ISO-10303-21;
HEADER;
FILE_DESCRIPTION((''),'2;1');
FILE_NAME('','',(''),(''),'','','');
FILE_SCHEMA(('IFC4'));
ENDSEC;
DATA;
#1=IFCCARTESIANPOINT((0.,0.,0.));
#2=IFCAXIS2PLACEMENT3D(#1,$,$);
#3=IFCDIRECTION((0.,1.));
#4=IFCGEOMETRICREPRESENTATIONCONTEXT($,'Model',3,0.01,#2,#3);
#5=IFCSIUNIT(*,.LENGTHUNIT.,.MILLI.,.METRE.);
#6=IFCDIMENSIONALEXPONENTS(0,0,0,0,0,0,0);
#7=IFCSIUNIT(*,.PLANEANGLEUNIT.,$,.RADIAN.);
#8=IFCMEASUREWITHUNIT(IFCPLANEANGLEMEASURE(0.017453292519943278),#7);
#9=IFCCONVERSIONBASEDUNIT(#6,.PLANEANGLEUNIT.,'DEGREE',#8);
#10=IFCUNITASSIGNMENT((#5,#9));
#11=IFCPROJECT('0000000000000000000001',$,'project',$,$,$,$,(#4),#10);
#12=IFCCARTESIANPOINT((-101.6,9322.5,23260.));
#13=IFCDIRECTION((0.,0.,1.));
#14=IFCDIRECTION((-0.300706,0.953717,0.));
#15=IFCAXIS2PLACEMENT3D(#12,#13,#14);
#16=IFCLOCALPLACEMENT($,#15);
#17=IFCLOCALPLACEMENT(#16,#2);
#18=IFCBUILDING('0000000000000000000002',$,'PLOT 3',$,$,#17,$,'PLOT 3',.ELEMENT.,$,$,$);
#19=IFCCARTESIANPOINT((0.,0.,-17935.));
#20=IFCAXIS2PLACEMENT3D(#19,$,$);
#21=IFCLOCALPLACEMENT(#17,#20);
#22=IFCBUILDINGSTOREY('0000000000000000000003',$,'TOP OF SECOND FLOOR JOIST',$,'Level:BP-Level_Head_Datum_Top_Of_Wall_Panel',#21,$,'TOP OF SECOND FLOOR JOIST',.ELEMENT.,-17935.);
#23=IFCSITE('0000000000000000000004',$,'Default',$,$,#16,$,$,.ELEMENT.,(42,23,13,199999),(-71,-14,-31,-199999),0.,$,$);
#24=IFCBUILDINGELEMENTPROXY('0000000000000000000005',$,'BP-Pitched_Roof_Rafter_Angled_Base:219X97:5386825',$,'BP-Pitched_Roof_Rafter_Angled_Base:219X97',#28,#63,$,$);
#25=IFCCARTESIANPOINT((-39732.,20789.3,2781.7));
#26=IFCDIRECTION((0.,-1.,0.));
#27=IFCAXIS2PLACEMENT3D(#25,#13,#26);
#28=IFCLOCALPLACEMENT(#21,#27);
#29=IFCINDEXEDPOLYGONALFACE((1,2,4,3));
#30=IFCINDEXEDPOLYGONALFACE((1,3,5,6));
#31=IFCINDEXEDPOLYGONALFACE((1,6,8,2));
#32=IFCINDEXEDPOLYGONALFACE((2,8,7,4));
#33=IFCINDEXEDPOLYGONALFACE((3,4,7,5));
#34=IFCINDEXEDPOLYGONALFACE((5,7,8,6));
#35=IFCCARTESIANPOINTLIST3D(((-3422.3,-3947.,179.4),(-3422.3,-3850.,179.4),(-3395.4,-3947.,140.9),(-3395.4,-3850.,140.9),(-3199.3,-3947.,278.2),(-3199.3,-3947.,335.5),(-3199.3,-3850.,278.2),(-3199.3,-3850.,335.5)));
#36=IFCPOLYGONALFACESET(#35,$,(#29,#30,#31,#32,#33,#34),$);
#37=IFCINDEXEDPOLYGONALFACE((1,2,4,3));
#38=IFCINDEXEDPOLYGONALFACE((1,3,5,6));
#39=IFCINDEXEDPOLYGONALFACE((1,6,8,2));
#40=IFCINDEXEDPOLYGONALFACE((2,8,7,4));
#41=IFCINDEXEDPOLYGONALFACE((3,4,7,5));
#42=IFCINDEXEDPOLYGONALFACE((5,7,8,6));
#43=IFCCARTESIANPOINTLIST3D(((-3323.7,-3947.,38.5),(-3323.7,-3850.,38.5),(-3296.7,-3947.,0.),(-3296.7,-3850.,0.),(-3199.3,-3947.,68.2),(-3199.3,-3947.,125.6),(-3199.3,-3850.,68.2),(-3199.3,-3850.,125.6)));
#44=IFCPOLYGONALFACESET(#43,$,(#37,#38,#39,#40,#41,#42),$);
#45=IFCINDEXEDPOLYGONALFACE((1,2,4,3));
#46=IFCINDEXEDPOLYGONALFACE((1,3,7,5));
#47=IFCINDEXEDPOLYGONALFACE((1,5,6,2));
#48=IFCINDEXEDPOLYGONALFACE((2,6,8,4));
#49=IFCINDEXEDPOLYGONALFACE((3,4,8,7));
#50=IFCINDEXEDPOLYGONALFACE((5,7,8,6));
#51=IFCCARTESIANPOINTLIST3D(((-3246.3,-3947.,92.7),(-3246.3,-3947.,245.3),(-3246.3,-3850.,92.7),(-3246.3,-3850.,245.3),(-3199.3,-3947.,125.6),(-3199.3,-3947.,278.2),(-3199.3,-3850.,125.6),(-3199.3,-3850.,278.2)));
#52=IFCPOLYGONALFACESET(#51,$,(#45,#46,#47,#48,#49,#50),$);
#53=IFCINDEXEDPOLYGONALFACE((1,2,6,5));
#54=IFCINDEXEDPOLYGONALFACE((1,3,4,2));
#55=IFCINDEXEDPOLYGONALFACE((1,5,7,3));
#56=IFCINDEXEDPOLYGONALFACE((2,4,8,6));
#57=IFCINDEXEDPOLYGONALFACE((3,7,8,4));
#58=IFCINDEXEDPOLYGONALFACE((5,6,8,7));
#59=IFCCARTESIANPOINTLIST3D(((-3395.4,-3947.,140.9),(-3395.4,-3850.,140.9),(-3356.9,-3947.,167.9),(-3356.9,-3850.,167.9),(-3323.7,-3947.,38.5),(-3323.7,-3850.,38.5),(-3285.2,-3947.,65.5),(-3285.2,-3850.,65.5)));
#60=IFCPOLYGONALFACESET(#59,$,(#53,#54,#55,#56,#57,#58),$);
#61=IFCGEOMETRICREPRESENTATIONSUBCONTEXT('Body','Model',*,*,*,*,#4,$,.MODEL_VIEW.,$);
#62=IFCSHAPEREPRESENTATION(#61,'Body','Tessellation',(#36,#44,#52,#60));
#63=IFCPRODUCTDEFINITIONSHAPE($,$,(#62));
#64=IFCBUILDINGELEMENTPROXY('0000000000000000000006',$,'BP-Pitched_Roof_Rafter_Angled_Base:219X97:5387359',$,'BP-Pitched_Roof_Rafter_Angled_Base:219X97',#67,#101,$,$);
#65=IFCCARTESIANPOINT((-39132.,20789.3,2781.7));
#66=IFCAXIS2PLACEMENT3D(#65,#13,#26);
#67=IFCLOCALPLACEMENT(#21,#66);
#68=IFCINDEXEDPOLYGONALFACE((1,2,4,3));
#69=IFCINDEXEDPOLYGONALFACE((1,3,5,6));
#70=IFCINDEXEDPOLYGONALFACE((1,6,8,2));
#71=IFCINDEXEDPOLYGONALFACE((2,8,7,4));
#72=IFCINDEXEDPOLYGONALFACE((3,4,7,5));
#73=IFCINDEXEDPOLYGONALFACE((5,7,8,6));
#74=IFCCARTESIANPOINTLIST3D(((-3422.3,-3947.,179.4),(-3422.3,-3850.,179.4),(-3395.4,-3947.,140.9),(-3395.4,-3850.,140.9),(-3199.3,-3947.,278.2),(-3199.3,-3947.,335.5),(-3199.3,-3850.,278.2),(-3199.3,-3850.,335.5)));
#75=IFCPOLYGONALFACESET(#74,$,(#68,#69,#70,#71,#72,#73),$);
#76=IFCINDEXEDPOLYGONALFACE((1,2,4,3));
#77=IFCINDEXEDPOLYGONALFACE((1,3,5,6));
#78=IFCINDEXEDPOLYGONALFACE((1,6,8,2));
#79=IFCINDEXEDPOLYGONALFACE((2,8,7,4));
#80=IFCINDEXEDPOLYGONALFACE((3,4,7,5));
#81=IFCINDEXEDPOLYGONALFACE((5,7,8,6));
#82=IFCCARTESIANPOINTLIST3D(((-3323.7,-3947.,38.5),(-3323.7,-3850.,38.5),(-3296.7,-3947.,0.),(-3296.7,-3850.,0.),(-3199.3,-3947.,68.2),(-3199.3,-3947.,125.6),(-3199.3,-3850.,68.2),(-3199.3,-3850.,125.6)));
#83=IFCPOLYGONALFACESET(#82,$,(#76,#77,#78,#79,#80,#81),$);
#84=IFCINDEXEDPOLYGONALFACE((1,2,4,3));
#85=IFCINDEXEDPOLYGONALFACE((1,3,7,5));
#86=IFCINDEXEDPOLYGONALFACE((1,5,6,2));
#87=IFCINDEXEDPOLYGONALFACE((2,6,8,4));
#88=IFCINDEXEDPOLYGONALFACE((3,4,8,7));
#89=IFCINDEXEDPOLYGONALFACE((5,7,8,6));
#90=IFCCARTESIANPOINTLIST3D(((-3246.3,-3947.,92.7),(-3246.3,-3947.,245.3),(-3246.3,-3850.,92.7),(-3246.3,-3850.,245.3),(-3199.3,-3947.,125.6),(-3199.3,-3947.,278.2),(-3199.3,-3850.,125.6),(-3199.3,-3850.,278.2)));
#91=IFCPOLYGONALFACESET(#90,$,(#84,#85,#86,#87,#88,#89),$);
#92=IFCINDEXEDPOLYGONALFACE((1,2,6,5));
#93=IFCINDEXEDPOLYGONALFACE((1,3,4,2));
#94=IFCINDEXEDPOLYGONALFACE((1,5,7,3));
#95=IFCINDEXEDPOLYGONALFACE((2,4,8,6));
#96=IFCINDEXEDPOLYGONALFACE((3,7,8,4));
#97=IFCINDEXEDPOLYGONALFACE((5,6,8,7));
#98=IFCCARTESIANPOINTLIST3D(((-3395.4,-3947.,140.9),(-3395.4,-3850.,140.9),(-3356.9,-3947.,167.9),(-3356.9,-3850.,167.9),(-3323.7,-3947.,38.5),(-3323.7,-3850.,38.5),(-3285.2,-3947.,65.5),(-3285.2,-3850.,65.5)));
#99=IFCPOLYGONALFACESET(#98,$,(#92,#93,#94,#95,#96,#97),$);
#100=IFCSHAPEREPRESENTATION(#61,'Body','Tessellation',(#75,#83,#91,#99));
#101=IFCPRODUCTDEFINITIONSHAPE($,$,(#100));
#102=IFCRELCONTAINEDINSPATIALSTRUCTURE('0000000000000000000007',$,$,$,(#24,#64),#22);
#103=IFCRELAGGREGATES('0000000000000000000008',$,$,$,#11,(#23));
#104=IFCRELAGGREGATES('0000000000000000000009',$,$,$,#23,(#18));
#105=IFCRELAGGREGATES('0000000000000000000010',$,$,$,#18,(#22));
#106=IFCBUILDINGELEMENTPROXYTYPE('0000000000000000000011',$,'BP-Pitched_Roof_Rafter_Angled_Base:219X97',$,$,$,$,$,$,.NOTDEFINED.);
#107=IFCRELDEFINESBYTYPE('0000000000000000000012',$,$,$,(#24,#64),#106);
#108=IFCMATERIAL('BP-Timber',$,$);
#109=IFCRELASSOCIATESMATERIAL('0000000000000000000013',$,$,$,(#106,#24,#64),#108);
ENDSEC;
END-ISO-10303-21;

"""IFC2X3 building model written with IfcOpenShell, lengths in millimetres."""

from ifc_helpers import new_model, entity, si_unit, converted_unit, direction, frame, frame_2d, origin, place, context, subcontext, project, spatial, polyline, rectangle, outline, extrude, source, transform, mapped, material, type_object, type_shapes, element, save


model = new_model("IFC2X3")

# Units and contexts
model_context = context("Model", 3, precision=0.01, world=origin(), true_north=direction((0.0, 1.0)))
body_context = subcontext(model_context, "Body", "Model", "MODEL_VIEW")
ifc_project = project(units=[si_unit("LENGTHUNIT", "METRE", prefix="MILLI"), converted_unit("PLANEANGLEUNIT", "DEGREE", entity("IfcPlaneAngleMeasure", 0.017453292519943278), si_unit("PLANEANGLEUNIT", "RADIAN"), dimensions=[0, 0, 0, 0, 0, 0, 0])], contexts=[model_context])

# Site, building, storey
site_placement = place(None, frame((-101.6, 9322.5, 23260.0), z_axis=(0.0, 0.0, 1.0), x_axis=(-0.300706, 0.953717, 0.0)))
site = spatial("IfcSite", under=ifc_project, at=site_placement, Name="Default", CompositionType="ELEMENT", RefLatitude=(42, 23, 13, 199999), RefLongitude=(-71, -14, -31, -199999), RefElevation=0.0)
building_placement = place(site_placement, origin())
building = spatial("IfcBuilding", under=site, at=building_placement, Name="PLOT 3", LongName="PLOT 3", CompositionType="ELEMENT")
storey_placement = place(building_placement, frame((0.0, 0.0, -17935.0)))
storey = spatial("IfcBuildingStorey", under=building, at=storey_placement, Name="TOP OF SECOND FLOOR JOIST", ObjectType="Level:BP-Level_Head_Datum_Top_Of_Wall_Panel", LongName="TOP OF SECOND FLOOR JOIST", CompositionType="ELEMENT", Elevation=-17935.0)

# Building element proxies
ifc_material_1 = material(Name="BP-Timber")
building_element_proxy_type_1 = type_object("IfcBuildingElementProxyType", Name="BP-Pitched_Roof_Rafter_Angled_Base:219X97", PredefinedType="NOTDEFINED", material=ifc_material_1)
shared_shape_1 = source(origin(), body_context, "Body", "SweptSolid", [
    extrude(outline(polyline([(-102.0, -104.8), (-44.7, -104.8), (92.6, 91.3), (54.1, 118.2), (-102.0, -104.8)])), frame((-3304.1, -3947.0, 233.5), z_axis=(0.0, 1.0, 0.0), x_axis=(0.0, 0.0, -1.0)), (0.0, 0.0, 1.0), 97.0),
    extrude(outline(polyline([(-67.5, -55.4), (-10.1, -55.4), (58.1, 42.0), (19.6, 68.9), (-67.5, -55.4)])), frame((-3254.8, -3947.0, 58.1), z_axis=(0.0, 1.0, 0.0), x_axis=(0.0, 0.0, -1.0)), (0.0, 0.0, 1.0), 97.0),
    extrude(outline(polyline([(15.1, -62.5), (72.5, -62.5), (-15.1, 62.5), (-72.5, 62.5), (15.1, -62.5)])), frame((-3222.8, -3947.0, 185.4), z_axis=(0.0, 1.0, 0.0), x_axis=(0.819152, 0.0, 0.573576)), (0.0, 0.0, 1.0), 97.0),
    extrude(rectangle(XDim=47.0, YDim=97.0, at=frame_2d((0.0, 0.0), x_axis=(1.0, 0.0))), frame((-3304.4, -3898.5, 52.0), z_axis=(-0.573576, 0.0, 0.819152), x_axis=(-0.819152, 0.0, -0.573576)), (0.0, 0.0, 1.0), 125.0),
])
type_shapes(building_element_proxy_type_1, [shared_shape_1])
for number, where, z_axis, x_axis, name in (
    (1, (-39732.0, 20789.3, 2781.7), (0.0, 0.0, 1.0), (0.0, -1.0, 0.0), "BP-Pitched_Roof_Rafter_Angled_Base:219X97:5386825"),
    (2, (-39132.0, 20789.3, 2781.7), (0.0, 0.0, 1.0), (0.0, -1.0, 0.0), "BP-Pitched_Roof_Rafter_Angled_Base:219X97:5387359"),
):
    element("IfcBuildingElementProxy", number, at=place(storey_placement, frame(where, z_axis=z_axis, x_axis=x_axis)), inside=storey, type_object=building_element_proxy_type_1, material=ifc_material_1, Name=name, ObjectType="BP-Pitched_Roof_Rafter_Angled_Base:219X97", context=body_context, shape_type="MappedRepresentation", body=[
        mapped(shared_shape_1, transform((0.0, 0.0, 0.0), scale=1.0)),
    ])

save(model, "model.ifc")
